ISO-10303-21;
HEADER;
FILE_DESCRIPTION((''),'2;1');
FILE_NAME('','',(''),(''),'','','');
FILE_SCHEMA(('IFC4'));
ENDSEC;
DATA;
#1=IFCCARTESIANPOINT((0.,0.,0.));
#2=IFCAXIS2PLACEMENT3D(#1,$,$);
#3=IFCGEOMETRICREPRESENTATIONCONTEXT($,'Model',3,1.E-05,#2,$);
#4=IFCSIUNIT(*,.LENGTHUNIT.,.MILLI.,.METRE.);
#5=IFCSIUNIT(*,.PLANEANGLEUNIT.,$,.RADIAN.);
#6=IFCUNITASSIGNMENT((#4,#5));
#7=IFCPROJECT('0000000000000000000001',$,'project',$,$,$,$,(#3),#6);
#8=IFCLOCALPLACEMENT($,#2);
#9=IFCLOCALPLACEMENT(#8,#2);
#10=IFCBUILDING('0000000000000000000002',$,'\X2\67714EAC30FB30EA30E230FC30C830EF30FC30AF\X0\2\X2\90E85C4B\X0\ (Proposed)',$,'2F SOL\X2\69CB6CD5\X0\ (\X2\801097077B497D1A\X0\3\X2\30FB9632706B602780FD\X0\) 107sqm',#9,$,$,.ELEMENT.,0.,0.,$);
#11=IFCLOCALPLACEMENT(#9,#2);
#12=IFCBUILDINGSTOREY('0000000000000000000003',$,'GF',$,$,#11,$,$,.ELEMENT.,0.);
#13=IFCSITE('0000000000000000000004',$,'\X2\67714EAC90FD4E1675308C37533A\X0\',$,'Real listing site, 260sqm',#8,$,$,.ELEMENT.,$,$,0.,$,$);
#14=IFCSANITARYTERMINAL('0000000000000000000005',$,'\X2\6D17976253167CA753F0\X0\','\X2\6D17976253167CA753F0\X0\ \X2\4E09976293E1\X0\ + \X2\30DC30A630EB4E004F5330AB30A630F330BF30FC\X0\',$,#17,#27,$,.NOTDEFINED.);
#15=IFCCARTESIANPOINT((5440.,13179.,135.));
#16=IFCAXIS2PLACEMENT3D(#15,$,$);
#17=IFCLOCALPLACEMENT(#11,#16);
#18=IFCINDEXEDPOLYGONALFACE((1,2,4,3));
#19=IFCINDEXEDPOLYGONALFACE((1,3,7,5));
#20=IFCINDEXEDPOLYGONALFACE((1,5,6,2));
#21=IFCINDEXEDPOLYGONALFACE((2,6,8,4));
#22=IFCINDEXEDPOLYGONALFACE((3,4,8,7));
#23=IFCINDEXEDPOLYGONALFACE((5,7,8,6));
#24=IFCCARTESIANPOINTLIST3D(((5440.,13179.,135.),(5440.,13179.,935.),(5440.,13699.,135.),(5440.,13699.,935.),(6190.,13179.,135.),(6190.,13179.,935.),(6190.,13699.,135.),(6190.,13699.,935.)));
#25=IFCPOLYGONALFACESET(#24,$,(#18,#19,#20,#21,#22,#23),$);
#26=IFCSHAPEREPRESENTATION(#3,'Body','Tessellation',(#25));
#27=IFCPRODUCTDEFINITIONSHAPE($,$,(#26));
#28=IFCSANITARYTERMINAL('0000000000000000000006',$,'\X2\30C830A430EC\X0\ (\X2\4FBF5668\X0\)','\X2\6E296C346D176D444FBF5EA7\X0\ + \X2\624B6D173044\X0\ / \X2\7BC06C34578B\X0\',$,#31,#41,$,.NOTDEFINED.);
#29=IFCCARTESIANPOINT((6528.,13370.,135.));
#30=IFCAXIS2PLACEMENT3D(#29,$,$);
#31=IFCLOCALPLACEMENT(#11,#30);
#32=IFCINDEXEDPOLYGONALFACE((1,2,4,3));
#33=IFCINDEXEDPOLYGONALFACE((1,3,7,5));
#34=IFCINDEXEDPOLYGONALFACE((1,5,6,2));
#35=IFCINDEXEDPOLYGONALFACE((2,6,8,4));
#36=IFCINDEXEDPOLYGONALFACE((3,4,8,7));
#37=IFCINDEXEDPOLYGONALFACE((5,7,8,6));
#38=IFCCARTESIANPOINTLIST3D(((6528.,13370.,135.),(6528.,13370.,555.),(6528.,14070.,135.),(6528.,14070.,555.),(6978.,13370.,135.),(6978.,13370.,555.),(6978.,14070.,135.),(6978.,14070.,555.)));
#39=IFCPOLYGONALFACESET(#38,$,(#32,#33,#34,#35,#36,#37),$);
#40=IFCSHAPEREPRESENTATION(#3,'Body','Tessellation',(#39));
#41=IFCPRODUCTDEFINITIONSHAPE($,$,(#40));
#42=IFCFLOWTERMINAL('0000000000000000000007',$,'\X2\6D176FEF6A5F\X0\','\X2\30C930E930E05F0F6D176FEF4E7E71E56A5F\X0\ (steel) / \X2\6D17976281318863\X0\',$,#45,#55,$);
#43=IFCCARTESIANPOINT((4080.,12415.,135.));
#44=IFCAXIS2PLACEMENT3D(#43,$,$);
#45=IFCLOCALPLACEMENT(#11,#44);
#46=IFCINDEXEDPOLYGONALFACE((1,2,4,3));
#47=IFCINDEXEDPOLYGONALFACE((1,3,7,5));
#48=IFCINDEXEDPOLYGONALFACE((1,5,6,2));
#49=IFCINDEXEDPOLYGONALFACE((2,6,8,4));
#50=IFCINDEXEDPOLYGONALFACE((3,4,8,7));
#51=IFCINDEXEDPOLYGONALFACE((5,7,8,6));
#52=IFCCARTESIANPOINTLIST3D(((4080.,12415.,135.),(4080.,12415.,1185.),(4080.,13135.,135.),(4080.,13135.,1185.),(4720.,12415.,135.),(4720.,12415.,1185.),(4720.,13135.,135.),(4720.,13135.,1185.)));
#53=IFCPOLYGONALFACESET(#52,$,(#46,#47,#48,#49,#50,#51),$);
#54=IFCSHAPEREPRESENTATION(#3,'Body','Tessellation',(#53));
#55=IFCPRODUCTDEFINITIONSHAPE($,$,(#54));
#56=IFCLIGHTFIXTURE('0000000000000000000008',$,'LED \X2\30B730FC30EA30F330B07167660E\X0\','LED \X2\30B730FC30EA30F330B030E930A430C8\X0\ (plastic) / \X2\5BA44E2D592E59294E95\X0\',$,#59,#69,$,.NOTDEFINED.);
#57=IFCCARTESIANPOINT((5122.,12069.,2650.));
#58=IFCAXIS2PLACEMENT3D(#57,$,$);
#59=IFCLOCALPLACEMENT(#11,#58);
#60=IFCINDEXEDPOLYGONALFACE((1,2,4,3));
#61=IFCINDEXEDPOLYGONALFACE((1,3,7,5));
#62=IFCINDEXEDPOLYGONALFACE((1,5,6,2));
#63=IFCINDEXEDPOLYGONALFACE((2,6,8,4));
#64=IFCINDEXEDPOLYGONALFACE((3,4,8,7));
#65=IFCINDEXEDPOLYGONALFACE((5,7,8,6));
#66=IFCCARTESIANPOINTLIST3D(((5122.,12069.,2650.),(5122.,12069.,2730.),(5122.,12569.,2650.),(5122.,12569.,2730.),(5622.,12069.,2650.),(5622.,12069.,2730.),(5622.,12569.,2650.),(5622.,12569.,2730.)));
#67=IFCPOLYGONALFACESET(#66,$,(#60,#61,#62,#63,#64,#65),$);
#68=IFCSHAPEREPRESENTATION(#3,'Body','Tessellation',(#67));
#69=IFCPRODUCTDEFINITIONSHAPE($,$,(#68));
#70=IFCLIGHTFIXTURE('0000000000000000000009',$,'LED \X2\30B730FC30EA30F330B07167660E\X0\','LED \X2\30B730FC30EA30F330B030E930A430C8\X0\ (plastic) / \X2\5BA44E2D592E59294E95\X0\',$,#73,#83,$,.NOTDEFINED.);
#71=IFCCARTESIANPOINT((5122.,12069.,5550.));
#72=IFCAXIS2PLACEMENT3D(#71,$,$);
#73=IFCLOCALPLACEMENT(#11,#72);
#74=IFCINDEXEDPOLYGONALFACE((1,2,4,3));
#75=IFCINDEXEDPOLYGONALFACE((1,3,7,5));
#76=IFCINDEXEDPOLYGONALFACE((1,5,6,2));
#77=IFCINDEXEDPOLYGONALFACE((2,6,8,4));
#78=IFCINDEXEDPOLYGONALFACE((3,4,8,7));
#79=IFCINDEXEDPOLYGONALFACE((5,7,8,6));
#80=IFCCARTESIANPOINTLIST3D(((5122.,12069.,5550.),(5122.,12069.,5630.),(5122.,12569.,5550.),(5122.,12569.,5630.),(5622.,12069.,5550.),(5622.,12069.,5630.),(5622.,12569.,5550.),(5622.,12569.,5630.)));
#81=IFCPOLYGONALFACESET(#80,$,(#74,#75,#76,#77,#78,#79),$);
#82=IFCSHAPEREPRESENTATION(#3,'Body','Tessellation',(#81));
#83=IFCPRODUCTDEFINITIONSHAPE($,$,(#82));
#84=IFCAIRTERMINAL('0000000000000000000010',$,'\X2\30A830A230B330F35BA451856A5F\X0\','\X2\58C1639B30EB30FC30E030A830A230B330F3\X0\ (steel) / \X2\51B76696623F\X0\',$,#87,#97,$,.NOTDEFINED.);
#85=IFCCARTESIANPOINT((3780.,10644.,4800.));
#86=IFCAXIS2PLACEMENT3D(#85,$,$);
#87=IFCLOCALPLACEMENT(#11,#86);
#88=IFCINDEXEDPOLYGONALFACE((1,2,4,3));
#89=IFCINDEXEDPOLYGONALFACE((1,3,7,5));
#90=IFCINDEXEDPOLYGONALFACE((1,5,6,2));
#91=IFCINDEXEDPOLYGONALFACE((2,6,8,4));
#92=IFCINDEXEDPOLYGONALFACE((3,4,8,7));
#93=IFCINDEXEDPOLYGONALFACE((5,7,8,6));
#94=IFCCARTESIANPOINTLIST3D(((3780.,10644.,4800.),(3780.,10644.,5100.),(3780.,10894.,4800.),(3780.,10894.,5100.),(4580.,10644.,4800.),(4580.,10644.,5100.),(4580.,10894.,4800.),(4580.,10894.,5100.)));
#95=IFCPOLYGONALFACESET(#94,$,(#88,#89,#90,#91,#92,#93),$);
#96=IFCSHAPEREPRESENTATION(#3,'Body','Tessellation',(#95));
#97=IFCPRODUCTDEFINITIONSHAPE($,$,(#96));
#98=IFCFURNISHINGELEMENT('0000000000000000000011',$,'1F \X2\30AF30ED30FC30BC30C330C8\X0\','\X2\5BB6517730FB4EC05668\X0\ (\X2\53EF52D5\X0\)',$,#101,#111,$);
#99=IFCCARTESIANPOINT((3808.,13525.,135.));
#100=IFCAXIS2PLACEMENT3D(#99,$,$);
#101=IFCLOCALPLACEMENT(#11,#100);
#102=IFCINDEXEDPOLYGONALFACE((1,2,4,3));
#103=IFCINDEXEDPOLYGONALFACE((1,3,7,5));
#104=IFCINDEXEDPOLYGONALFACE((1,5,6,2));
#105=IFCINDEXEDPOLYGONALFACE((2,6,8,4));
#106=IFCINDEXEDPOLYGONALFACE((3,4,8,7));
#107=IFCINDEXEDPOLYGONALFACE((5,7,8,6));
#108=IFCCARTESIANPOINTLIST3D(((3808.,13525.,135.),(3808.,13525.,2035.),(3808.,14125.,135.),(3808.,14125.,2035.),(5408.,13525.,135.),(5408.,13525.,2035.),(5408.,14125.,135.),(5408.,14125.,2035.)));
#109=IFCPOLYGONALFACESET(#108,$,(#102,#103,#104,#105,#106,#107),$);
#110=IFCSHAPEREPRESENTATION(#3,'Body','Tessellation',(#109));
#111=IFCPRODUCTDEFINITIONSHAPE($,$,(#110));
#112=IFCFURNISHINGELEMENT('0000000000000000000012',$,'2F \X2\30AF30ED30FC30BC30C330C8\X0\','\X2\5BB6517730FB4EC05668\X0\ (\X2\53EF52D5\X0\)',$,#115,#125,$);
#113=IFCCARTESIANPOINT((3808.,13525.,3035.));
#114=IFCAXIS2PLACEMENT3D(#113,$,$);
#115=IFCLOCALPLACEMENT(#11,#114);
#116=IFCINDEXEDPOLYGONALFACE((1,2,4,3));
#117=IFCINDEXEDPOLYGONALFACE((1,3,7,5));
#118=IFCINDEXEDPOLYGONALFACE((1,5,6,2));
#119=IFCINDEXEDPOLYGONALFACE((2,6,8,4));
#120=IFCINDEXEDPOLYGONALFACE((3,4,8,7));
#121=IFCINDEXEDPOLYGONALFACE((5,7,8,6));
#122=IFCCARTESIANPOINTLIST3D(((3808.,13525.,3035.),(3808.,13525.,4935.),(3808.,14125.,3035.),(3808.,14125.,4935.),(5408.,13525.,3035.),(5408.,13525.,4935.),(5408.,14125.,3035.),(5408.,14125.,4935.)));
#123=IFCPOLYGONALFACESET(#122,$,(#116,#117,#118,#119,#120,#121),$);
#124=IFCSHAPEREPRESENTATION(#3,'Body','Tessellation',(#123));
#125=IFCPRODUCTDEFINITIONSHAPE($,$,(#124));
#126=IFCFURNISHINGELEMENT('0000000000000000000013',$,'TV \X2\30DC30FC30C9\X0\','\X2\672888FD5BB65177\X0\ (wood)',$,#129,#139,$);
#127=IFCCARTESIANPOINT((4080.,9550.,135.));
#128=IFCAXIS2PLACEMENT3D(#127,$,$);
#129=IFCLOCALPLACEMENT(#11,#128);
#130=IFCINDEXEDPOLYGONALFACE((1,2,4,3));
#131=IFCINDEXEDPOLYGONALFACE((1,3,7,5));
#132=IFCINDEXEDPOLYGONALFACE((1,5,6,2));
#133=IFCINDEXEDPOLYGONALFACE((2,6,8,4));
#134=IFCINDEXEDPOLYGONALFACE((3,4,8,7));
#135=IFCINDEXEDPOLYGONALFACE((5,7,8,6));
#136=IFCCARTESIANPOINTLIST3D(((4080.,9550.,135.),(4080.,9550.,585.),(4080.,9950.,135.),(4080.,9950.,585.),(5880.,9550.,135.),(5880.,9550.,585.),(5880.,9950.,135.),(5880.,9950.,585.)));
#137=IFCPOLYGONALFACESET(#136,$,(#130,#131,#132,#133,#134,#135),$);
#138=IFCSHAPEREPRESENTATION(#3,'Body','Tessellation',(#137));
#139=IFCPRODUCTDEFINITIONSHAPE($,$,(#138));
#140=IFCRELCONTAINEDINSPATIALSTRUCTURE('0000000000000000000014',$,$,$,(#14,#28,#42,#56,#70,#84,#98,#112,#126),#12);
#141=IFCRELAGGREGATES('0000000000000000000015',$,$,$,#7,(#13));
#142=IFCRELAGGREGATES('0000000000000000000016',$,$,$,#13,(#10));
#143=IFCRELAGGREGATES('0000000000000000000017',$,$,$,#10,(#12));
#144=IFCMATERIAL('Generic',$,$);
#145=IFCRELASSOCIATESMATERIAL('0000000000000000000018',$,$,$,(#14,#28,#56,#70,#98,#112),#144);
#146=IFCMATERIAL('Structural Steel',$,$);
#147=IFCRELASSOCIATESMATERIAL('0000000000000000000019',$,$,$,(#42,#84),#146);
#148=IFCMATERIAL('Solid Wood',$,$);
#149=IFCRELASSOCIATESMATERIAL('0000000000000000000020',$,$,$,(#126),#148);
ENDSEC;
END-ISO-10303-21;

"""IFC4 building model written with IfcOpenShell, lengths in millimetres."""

from ifc_helpers import new_model, si_unit, frame, frame_2d, origin, place, context, project, spatial, rectangle, extrude, material, element, save


model = new_model("IFC4")

# Units and contexts
model_context = context("Model", 3, precision=1e-05, world=origin())
ifc_project = project(units=[si_unit("LENGTHUNIT", "METRE", prefix="MILLI"), si_unit("PLANEANGLEUNIT", "RADIAN")], contexts=[model_context])

# Site, building, storey
site_placement = place(None, origin())
site = spatial("IfcSite", under=ifc_project, at=site_placement, Name="東京都世田谷区", ObjectType="Real listing site, 260sqm", CompositionType="ELEMENT", RefElevation=0.0)
building_placement = place(site_placement, origin())
building = spatial("IfcBuilding", under=site, at=building_placement, Name="東京・リモートワーク2部屋 (Proposed)", ObjectType="2F SOL構法 (耐震等級3・防火性能) 107sqm", CompositionType="ELEMENT", ElevationOfRefHeight=0.0, ElevationOfTerrain=0.0)
storey_placement = place(building_placement, origin())
storey = spatial("IfcBuildingStorey", under=building, at=storey_placement, Name="GF", CompositionType="ELEMENT", Elevation=0.0)

# Shared definitions
ifc_material_1 = material(Name="Solid Wood")

# Sanitary terminals
ifc_material_2 = material(Name="Generic")
sanitary_terminal_1_placement = place(storey_placement, frame((5440.0, 13179.0, 135.0)))
element("IfcSanitaryTerminal", 1, at=sanitary_terminal_1_placement, inside=storey, material=ifc_material_2, Name="洗面化粧台", Description="洗面化粧台 三面鏡 + ボウル一体カウンター", PredefinedType="NOTDEFINED", context=model_context, shape_type="SweptSolid", body=[
    extrude(rectangle(XDim=750.0, YDim=520.0, at=frame_2d((375.0, 260.0))), frame((5440.0, 13179.0, 135.0)), (0.0, 0.0, 1.0), 800.0),
])
sanitary_terminal_2_placement = place(storey_placement, frame((6528.0, 13370.0, 135.0)))
element("IfcSanitaryTerminal", 2, at=sanitary_terminal_2_placement, inside=storey, material=ifc_material_2, Name="トイレ (便器)", Description="温水洗浄便座 + 手洗い / 節水型", PredefinedType="NOTDEFINED", context=model_context, shape_type="SweptSolid", body=[
    extrude(rectangle(XDim=450.0, YDim=700.0, at=frame_2d((225.0, 350.0))), frame((6528.0, 13370.0, 135.0)), (0.0, 0.0, 1.0), 420.0),
])

# Flow terminal
ifc_material_3 = material(Name="Structural Steel")
flow_terminal_placement = place(storey_placement, frame((4080.0, 12415.0, 135.0)))
element("IfcFlowTerminal", 3, at=flow_terminal_placement, inside=storey, material=ifc_material_3, Name="洗濯機", Description="ドラム式洗濯乾燥機 (steel) / 洗面脱衣", context=model_context, shape_type="SweptSolid", body=[
    extrude(rectangle(XDim=640.0, YDim=720.0, at=frame_2d((320.0, 360.0))), frame((4080.0, 12415.0, 135.0)), (0.0, 0.0, 1.0), 1050.0),
])

# Light fixtures
light_fixture_1_placement = place(storey_placement, frame((5122.0, 12069.0, 2650.0)))
element("IfcLightFixture", 4, at=light_fixture_1_placement, inside=storey, material=ifc_material_2, Name="LED シーリング照明", Description="LED シーリングライト (plastic) / 室中央天井", PredefinedType="NOTDEFINED", context=model_context, shape_type="SweptSolid", body=[
    extrude(rectangle(XDim=500.0, YDim=500.0, at=frame_2d((250.0, 250.0))), frame((5122.0, 12069.0, 2650.0)), (0.0, 0.0, 1.0), 80.0),
])
light_fixture_2_placement = place(storey_placement, frame((5122.0, 12069.0, 5550.0)))
element("IfcLightFixture", 5, at=light_fixture_2_placement, inside=storey, material=ifc_material_2, Name="LED シーリング照明", Description="LED シーリングライト (plastic) / 室中央天井", PredefinedType="NOTDEFINED", context=model_context, shape_type="SweptSolid", body=[
    extrude(rectangle(XDim=500.0, YDim=500.0, at=frame_2d((250.0, 250.0))), frame((5122.0, 12069.0, 5550.0)), (0.0, 0.0, 1.0), 80.0),
])

# Air terminal
air_terminal_placement = place(storey_placement, frame((3780.0, 10644.0, 4800.0)))
element("IfcAirTerminal", 6, at=air_terminal_placement, inside=storey, material=ifc_material_3, Name="エアコン室内機", Description="壁掛ルームエアコン (steel) / 冷暖房", PredefinedType="NOTDEFINED", context=model_context, shape_type="SweptSolid", body=[
    extrude(rectangle(XDim=800.0, YDim=250.0, at=frame_2d((400.0, 125.0))), frame((3780.0, 10644.0, 4800.0)), (0.0, 0.0, 1.0), 300.0),
])

# Furnishing elements
furnishing_1_placement = place(storey_placement, frame((3808.0, 13525.0, 135.0)))
element("IfcFurnishingElement", 7, at=furnishing_1_placement, inside=storey, material=ifc_material_2, Name="1F クローゼット", Description="家具・什器 (可動)", context=model_context, shape_type="SweptSolid", body=[
    extrude(rectangle(XDim=1600.0, YDim=600.0, at=frame_2d((800.0, 300.0))), frame((3808.0, 13525.0, 135.0)), (0.0, 0.0, 1.0), 1900.0),
])
furnishing_2_placement = place(storey_placement, frame((3808.0, 13525.0, 3035.0)))
element("IfcFurnishingElement", 8, at=furnishing_2_placement, inside=storey, material=ifc_material_2, Name="2F クローゼット", Description="家具・什器 (可動)", context=model_context, shape_type="SweptSolid", body=[
    extrude(rectangle(XDim=1600.0, YDim=600.0, at=frame_2d((800.0, 300.0))), frame((3808.0, 13525.0, 3035.0)), (0.0, 0.0, 1.0), 1900.0),
])
furnishing_3_placement = place(storey_placement, frame((4080.0, 9550.0, 135.0)))
element("IfcFurnishingElement", 9, at=furnishing_3_placement, inside=storey, material=ifc_material_1, Name="TV ボード", Description="木製家具 (wood)", context=model_context, shape_type="SweptSolid", body=[
    extrude(rectangle(XDim=1800.0, YDim=400.0, at=frame_2d((900.0, 200.0))), frame((4080.0, 9550.0, 135.0)), (0.0, 0.0, 1.0), 450.0),
])

save(model, "model.ifc")
